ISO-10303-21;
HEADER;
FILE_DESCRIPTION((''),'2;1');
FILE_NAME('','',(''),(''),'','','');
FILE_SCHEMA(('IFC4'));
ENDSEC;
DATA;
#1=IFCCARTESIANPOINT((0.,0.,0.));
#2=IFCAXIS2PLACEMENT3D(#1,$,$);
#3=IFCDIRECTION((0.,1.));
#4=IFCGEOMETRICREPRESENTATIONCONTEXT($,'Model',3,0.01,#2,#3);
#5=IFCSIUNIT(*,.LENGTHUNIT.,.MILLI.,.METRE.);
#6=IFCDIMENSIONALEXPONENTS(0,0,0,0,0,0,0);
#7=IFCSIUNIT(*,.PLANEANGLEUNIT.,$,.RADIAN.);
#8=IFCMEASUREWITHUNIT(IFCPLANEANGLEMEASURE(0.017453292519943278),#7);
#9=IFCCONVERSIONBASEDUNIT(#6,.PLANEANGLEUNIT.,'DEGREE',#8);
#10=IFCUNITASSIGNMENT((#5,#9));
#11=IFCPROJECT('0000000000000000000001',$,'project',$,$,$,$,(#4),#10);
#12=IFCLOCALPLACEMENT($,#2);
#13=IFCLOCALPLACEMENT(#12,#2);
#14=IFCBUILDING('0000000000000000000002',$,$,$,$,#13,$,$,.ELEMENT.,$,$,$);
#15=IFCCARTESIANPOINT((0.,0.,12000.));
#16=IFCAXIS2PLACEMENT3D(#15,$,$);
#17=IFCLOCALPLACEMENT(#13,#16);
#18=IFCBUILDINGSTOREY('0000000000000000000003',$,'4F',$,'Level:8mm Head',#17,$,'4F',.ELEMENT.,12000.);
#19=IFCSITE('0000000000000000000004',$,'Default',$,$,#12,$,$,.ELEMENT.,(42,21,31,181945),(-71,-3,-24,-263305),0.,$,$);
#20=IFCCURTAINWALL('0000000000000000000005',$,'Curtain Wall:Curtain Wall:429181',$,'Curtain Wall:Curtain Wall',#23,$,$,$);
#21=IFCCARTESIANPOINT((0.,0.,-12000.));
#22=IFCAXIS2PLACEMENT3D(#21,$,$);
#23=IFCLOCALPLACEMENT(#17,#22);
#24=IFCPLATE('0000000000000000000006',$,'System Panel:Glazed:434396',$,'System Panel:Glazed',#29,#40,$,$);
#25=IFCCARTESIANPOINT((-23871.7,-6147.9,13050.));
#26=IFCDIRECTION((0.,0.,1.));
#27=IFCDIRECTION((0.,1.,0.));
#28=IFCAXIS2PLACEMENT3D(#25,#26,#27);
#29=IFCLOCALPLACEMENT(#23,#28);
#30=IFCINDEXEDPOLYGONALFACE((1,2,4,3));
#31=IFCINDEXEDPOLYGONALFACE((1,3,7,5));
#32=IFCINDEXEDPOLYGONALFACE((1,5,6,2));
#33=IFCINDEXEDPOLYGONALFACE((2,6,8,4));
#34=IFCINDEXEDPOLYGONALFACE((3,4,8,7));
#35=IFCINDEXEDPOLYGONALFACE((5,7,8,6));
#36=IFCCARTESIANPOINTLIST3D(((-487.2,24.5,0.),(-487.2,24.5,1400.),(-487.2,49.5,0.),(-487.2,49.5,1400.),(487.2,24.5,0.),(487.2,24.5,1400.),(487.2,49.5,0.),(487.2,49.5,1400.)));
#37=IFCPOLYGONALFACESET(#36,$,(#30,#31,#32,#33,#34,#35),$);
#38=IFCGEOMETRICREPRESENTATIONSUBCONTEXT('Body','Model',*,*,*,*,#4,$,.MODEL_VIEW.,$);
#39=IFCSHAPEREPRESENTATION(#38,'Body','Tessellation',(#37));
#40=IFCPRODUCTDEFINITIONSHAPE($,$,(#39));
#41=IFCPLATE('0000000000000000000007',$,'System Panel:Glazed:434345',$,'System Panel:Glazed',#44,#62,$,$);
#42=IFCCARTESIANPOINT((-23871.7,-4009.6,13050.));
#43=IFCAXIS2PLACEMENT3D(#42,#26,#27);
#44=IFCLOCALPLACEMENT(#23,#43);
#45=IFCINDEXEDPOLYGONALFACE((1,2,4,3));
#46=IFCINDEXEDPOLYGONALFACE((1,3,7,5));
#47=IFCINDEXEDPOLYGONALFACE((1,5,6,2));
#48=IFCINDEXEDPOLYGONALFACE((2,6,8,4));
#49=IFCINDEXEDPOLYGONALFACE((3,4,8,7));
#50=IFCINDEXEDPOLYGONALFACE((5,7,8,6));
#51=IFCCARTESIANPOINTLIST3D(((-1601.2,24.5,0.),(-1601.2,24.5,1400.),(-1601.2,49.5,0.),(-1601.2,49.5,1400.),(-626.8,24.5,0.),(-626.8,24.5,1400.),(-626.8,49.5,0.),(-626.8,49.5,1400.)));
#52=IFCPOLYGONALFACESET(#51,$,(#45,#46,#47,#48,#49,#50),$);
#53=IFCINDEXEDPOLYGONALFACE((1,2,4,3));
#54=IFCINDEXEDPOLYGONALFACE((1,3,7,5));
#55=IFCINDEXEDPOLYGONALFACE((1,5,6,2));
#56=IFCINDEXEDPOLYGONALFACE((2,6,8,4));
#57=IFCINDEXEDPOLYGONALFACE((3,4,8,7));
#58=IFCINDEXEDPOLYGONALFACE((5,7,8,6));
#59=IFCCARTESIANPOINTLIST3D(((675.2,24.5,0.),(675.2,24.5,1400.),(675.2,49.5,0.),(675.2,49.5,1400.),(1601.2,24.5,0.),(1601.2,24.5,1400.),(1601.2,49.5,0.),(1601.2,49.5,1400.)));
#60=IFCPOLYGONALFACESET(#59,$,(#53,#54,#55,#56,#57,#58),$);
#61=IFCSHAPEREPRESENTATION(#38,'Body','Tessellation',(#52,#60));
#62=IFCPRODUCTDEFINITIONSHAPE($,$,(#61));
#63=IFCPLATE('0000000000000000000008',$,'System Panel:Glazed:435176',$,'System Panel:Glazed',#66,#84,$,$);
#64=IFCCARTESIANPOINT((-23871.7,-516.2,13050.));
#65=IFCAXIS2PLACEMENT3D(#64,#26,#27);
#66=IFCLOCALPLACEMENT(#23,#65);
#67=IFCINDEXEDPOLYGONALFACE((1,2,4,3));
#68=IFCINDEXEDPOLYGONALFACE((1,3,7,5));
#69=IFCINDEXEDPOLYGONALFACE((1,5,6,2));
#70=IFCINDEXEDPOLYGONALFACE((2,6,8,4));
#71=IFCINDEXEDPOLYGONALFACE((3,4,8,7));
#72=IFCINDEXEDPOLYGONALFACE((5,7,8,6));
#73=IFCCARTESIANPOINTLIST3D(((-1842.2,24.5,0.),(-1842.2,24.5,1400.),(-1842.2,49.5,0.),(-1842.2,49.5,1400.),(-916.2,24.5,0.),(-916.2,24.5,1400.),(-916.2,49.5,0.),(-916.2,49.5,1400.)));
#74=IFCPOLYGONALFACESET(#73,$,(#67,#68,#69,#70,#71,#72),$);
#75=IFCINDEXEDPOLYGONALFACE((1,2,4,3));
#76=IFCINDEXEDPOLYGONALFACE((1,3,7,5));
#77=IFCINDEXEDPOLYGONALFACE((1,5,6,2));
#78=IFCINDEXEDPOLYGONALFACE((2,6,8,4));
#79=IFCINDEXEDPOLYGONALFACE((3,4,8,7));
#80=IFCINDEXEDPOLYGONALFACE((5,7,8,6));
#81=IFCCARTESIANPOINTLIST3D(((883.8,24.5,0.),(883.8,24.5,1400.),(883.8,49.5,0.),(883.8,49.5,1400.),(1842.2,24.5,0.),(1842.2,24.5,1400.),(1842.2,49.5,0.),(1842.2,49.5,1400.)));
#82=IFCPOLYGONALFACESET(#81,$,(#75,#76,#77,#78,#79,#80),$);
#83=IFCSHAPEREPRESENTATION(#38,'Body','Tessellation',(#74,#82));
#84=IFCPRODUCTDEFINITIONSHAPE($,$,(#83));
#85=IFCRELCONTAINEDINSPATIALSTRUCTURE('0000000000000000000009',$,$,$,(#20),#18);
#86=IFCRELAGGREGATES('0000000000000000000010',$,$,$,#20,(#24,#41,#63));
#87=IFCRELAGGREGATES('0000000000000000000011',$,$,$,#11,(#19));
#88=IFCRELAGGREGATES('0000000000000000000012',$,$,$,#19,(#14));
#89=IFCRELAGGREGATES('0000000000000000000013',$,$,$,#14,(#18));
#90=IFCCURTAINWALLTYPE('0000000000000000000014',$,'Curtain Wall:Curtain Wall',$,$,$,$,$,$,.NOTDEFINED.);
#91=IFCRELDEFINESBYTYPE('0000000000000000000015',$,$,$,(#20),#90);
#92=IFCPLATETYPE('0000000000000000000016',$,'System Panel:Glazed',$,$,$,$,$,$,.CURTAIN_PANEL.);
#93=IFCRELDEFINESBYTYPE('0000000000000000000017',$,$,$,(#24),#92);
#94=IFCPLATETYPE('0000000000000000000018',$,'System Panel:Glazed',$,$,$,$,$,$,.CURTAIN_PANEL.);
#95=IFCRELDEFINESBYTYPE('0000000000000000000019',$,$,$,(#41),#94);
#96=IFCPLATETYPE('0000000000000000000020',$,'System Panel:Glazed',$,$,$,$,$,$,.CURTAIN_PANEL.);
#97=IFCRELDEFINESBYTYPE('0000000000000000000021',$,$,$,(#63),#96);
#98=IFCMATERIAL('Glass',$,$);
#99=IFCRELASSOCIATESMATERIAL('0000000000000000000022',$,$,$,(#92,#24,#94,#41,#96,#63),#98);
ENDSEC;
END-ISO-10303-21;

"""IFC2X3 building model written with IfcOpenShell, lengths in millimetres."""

from ifc_helpers import new_model, entity, si_unit, converted_unit, direction, frame, frame_2d, origin, origin_2d_with_axis, place, context, subcontext, project, spatial, rectangle, extrude, source, transform, mapped, material, type_object, type_shapes, element, aggregate, save


model = new_model("IFC2X3")

# Units and contexts
model_context = context("Model", 3, precision=0.01, world=origin(), true_north=direction((0.0, 1.0)))
body_context = subcontext(model_context, "Body", "Model", "MODEL_VIEW")
ifc_project = project(units=[si_unit("LENGTHUNIT", "METRE", prefix="MILLI"), converted_unit("PLANEANGLEUNIT", "DEGREE", entity("IfcPlaneAngleMeasure", 0.017453292519943278), si_unit("PLANEANGLEUNIT", "RADIAN"), dimensions=[0, 0, 0, 0, 0, 0, 0])], contexts=[model_context])

# Site, building, storey
site_placement = place(None, origin())
site = spatial("IfcSite", under=ifc_project, at=site_placement, Name="Default", CompositionType="ELEMENT", RefLatitude=(42, 21, 31, 181945), RefLongitude=(-71, -3, -24, -263305), RefElevation=0.0)
building_placement = place(site_placement, origin())
building = spatial("IfcBuilding", under=site, at=building_placement, CompositionType="ELEMENT")
storey_placement = place(building_placement, frame((0.0, 0.0, 12000.0)))
storey = spatial("IfcBuildingStorey", under=building, at=storey_placement, Name="4F", ObjectType="Level:8mm Head", LongName="4F", CompositionType="ELEMENT", Elevation=12000.0)

# Curtain wall, plates
curtain_wall_type = type_object("IfcCurtainWallType", Name="Curtain Wall:Curtain Wall", PredefinedType="NOTDEFINED")
curtain_wall_placement = place(storey_placement, frame((0.0, 0.0, -12000.0)))
curtain_wall = element("IfcCurtainWall", 1, at=curtain_wall_placement, inside=storey, type_object=curtain_wall_type, Name="Curtain Wall:Curtain Wall:429181", ObjectType="Curtain Wall:Curtain Wall")
ifc_material_1 = material(Name="Glass")
plate_type_1 = type_object("IfcPlateType", Name="System Panel:Glazed", PredefinedType="CURTAIN_PANEL", material=ifc_material_1)
shared_shape_1 = source(origin(), body_context, "Body", "SweptSolid", [
    extrude(rectangle(XDim=25.0, YDim=974.3, at=origin_2d_with_axis()), frame((0.0, 37.0, 0.0), z_axis=(0.0, 0.0, 1.0), x_axis=(0.0, 1.0, 0.0)), (0.0, 0.0, 1.0), 1400.0),
])
type_shapes(plate_type_1, [shared_shape_1])
plate_1_placement = place(curtain_wall_placement, frame((-23871.7, -6147.9, 13050.0), z_axis=(0.0, 0.0, 1.0), x_axis=(0.0, 1.0, 0.0)))
plate_1 = element("IfcPlate", 2, at=plate_1_placement, type_object=plate_type_1, material=ifc_material_1, Name="System Panel:Glazed:434396", ObjectType="System Panel:Glazed", context=body_context, shape_type="MappedRepresentation", body=[
    mapped(shared_shape_1, transform((0.0, 0.0, 0.0), scale=1.0)),
])
plate_type_2 = type_object("IfcPlateType", Name="System Panel:Glazed", PredefinedType="CURTAIN_PANEL", material=ifc_material_1)
shared_shape_2 = source(origin(), body_context, "Body", "SweptSolid", [
    extrude(rectangle(XDim=25.0, YDim=974.3, at=origin_2d_with_axis()), frame((-1114.0, 37.0, 0.0), z_axis=(0.0, 0.0, 1.0), x_axis=(0.0, 1.0, 0.0)), (0.0, 0.0, 1.0), 1400.0),
    extrude(rectangle(XDim=25.0, YDim=926.0, at=origin_2d_with_axis()), frame((1138.2, 37.0, 0.0), z_axis=(0.0, 0.0, 1.0), x_axis=(0.0, 1.0, 0.0)), (0.0, 0.0, 1.0), 1400.0),
])
type_shapes(plate_type_2, [shared_shape_2])
plate_2_placement = place(curtain_wall_placement, frame((-23871.7, -4009.6, 13050.0), z_axis=(0.0, 0.0, 1.0), x_axis=(0.0, 1.0, 0.0)))
plate_2 = element("IfcPlate", 3, at=plate_2_placement, type_object=plate_type_2, material=ifc_material_1, Name="System Panel:Glazed:434345", ObjectType="System Panel:Glazed", context=body_context, shape_type="MappedRepresentation", body=[
    mapped(shared_shape_2, transform((0.0, 0.0, 0.0), scale=1.0)),
])
plate_type_3 = type_object("IfcPlateType", Name="System Panel:Glazed", PredefinedType="CURTAIN_PANEL", material=ifc_material_1)
shared_shape_3 = source(origin(), body_context, "Body", "SweptSolid", [
    extrude(rectangle(XDim=25.0, YDim=926.0, at=frame_2d((0.0, 0.0), x_axis=(1.0, 0.0))), frame((-1379.2, 37.0, 0.0), z_axis=(0.0, 0.0, 1.0), x_axis=(0.0, 1.0, 0.0)), (0.0, 0.0, 1.0), 1400.0),
    extrude(rectangle(XDim=25.0, YDim=958.3, at=origin_2d_with_axis()), frame((1363.0, 37.0, 0.0), z_axis=(0.0, 0.0, 1.0), x_axis=(0.0, 1.0, 0.0)), (0.0, 0.0, 1.0), 1400.0),
])
type_shapes(plate_type_3, [shared_shape_3])
plate_3_placement = place(curtain_wall_placement, frame((-23871.7, -516.2, 13050.0), z_axis=(0.0, 0.0, 1.0), x_axis=(0.0, 1.0, 0.0)))
plate_3 = element("IfcPlate", 4, at=plate_3_placement, type_object=plate_type_3, material=ifc_material_1, Name="System Panel:Glazed:435176", ObjectType="System Panel:Glazed", context=body_context, shape_type="MappedRepresentation", body=[
    mapped(shared_shape_3, transform((0.0, 0.0, 0.0), scale=1.0)),
])
aggregate(curtain_wall, [plate_1, plate_2, plate_3])

save(model, "model.ifc")
